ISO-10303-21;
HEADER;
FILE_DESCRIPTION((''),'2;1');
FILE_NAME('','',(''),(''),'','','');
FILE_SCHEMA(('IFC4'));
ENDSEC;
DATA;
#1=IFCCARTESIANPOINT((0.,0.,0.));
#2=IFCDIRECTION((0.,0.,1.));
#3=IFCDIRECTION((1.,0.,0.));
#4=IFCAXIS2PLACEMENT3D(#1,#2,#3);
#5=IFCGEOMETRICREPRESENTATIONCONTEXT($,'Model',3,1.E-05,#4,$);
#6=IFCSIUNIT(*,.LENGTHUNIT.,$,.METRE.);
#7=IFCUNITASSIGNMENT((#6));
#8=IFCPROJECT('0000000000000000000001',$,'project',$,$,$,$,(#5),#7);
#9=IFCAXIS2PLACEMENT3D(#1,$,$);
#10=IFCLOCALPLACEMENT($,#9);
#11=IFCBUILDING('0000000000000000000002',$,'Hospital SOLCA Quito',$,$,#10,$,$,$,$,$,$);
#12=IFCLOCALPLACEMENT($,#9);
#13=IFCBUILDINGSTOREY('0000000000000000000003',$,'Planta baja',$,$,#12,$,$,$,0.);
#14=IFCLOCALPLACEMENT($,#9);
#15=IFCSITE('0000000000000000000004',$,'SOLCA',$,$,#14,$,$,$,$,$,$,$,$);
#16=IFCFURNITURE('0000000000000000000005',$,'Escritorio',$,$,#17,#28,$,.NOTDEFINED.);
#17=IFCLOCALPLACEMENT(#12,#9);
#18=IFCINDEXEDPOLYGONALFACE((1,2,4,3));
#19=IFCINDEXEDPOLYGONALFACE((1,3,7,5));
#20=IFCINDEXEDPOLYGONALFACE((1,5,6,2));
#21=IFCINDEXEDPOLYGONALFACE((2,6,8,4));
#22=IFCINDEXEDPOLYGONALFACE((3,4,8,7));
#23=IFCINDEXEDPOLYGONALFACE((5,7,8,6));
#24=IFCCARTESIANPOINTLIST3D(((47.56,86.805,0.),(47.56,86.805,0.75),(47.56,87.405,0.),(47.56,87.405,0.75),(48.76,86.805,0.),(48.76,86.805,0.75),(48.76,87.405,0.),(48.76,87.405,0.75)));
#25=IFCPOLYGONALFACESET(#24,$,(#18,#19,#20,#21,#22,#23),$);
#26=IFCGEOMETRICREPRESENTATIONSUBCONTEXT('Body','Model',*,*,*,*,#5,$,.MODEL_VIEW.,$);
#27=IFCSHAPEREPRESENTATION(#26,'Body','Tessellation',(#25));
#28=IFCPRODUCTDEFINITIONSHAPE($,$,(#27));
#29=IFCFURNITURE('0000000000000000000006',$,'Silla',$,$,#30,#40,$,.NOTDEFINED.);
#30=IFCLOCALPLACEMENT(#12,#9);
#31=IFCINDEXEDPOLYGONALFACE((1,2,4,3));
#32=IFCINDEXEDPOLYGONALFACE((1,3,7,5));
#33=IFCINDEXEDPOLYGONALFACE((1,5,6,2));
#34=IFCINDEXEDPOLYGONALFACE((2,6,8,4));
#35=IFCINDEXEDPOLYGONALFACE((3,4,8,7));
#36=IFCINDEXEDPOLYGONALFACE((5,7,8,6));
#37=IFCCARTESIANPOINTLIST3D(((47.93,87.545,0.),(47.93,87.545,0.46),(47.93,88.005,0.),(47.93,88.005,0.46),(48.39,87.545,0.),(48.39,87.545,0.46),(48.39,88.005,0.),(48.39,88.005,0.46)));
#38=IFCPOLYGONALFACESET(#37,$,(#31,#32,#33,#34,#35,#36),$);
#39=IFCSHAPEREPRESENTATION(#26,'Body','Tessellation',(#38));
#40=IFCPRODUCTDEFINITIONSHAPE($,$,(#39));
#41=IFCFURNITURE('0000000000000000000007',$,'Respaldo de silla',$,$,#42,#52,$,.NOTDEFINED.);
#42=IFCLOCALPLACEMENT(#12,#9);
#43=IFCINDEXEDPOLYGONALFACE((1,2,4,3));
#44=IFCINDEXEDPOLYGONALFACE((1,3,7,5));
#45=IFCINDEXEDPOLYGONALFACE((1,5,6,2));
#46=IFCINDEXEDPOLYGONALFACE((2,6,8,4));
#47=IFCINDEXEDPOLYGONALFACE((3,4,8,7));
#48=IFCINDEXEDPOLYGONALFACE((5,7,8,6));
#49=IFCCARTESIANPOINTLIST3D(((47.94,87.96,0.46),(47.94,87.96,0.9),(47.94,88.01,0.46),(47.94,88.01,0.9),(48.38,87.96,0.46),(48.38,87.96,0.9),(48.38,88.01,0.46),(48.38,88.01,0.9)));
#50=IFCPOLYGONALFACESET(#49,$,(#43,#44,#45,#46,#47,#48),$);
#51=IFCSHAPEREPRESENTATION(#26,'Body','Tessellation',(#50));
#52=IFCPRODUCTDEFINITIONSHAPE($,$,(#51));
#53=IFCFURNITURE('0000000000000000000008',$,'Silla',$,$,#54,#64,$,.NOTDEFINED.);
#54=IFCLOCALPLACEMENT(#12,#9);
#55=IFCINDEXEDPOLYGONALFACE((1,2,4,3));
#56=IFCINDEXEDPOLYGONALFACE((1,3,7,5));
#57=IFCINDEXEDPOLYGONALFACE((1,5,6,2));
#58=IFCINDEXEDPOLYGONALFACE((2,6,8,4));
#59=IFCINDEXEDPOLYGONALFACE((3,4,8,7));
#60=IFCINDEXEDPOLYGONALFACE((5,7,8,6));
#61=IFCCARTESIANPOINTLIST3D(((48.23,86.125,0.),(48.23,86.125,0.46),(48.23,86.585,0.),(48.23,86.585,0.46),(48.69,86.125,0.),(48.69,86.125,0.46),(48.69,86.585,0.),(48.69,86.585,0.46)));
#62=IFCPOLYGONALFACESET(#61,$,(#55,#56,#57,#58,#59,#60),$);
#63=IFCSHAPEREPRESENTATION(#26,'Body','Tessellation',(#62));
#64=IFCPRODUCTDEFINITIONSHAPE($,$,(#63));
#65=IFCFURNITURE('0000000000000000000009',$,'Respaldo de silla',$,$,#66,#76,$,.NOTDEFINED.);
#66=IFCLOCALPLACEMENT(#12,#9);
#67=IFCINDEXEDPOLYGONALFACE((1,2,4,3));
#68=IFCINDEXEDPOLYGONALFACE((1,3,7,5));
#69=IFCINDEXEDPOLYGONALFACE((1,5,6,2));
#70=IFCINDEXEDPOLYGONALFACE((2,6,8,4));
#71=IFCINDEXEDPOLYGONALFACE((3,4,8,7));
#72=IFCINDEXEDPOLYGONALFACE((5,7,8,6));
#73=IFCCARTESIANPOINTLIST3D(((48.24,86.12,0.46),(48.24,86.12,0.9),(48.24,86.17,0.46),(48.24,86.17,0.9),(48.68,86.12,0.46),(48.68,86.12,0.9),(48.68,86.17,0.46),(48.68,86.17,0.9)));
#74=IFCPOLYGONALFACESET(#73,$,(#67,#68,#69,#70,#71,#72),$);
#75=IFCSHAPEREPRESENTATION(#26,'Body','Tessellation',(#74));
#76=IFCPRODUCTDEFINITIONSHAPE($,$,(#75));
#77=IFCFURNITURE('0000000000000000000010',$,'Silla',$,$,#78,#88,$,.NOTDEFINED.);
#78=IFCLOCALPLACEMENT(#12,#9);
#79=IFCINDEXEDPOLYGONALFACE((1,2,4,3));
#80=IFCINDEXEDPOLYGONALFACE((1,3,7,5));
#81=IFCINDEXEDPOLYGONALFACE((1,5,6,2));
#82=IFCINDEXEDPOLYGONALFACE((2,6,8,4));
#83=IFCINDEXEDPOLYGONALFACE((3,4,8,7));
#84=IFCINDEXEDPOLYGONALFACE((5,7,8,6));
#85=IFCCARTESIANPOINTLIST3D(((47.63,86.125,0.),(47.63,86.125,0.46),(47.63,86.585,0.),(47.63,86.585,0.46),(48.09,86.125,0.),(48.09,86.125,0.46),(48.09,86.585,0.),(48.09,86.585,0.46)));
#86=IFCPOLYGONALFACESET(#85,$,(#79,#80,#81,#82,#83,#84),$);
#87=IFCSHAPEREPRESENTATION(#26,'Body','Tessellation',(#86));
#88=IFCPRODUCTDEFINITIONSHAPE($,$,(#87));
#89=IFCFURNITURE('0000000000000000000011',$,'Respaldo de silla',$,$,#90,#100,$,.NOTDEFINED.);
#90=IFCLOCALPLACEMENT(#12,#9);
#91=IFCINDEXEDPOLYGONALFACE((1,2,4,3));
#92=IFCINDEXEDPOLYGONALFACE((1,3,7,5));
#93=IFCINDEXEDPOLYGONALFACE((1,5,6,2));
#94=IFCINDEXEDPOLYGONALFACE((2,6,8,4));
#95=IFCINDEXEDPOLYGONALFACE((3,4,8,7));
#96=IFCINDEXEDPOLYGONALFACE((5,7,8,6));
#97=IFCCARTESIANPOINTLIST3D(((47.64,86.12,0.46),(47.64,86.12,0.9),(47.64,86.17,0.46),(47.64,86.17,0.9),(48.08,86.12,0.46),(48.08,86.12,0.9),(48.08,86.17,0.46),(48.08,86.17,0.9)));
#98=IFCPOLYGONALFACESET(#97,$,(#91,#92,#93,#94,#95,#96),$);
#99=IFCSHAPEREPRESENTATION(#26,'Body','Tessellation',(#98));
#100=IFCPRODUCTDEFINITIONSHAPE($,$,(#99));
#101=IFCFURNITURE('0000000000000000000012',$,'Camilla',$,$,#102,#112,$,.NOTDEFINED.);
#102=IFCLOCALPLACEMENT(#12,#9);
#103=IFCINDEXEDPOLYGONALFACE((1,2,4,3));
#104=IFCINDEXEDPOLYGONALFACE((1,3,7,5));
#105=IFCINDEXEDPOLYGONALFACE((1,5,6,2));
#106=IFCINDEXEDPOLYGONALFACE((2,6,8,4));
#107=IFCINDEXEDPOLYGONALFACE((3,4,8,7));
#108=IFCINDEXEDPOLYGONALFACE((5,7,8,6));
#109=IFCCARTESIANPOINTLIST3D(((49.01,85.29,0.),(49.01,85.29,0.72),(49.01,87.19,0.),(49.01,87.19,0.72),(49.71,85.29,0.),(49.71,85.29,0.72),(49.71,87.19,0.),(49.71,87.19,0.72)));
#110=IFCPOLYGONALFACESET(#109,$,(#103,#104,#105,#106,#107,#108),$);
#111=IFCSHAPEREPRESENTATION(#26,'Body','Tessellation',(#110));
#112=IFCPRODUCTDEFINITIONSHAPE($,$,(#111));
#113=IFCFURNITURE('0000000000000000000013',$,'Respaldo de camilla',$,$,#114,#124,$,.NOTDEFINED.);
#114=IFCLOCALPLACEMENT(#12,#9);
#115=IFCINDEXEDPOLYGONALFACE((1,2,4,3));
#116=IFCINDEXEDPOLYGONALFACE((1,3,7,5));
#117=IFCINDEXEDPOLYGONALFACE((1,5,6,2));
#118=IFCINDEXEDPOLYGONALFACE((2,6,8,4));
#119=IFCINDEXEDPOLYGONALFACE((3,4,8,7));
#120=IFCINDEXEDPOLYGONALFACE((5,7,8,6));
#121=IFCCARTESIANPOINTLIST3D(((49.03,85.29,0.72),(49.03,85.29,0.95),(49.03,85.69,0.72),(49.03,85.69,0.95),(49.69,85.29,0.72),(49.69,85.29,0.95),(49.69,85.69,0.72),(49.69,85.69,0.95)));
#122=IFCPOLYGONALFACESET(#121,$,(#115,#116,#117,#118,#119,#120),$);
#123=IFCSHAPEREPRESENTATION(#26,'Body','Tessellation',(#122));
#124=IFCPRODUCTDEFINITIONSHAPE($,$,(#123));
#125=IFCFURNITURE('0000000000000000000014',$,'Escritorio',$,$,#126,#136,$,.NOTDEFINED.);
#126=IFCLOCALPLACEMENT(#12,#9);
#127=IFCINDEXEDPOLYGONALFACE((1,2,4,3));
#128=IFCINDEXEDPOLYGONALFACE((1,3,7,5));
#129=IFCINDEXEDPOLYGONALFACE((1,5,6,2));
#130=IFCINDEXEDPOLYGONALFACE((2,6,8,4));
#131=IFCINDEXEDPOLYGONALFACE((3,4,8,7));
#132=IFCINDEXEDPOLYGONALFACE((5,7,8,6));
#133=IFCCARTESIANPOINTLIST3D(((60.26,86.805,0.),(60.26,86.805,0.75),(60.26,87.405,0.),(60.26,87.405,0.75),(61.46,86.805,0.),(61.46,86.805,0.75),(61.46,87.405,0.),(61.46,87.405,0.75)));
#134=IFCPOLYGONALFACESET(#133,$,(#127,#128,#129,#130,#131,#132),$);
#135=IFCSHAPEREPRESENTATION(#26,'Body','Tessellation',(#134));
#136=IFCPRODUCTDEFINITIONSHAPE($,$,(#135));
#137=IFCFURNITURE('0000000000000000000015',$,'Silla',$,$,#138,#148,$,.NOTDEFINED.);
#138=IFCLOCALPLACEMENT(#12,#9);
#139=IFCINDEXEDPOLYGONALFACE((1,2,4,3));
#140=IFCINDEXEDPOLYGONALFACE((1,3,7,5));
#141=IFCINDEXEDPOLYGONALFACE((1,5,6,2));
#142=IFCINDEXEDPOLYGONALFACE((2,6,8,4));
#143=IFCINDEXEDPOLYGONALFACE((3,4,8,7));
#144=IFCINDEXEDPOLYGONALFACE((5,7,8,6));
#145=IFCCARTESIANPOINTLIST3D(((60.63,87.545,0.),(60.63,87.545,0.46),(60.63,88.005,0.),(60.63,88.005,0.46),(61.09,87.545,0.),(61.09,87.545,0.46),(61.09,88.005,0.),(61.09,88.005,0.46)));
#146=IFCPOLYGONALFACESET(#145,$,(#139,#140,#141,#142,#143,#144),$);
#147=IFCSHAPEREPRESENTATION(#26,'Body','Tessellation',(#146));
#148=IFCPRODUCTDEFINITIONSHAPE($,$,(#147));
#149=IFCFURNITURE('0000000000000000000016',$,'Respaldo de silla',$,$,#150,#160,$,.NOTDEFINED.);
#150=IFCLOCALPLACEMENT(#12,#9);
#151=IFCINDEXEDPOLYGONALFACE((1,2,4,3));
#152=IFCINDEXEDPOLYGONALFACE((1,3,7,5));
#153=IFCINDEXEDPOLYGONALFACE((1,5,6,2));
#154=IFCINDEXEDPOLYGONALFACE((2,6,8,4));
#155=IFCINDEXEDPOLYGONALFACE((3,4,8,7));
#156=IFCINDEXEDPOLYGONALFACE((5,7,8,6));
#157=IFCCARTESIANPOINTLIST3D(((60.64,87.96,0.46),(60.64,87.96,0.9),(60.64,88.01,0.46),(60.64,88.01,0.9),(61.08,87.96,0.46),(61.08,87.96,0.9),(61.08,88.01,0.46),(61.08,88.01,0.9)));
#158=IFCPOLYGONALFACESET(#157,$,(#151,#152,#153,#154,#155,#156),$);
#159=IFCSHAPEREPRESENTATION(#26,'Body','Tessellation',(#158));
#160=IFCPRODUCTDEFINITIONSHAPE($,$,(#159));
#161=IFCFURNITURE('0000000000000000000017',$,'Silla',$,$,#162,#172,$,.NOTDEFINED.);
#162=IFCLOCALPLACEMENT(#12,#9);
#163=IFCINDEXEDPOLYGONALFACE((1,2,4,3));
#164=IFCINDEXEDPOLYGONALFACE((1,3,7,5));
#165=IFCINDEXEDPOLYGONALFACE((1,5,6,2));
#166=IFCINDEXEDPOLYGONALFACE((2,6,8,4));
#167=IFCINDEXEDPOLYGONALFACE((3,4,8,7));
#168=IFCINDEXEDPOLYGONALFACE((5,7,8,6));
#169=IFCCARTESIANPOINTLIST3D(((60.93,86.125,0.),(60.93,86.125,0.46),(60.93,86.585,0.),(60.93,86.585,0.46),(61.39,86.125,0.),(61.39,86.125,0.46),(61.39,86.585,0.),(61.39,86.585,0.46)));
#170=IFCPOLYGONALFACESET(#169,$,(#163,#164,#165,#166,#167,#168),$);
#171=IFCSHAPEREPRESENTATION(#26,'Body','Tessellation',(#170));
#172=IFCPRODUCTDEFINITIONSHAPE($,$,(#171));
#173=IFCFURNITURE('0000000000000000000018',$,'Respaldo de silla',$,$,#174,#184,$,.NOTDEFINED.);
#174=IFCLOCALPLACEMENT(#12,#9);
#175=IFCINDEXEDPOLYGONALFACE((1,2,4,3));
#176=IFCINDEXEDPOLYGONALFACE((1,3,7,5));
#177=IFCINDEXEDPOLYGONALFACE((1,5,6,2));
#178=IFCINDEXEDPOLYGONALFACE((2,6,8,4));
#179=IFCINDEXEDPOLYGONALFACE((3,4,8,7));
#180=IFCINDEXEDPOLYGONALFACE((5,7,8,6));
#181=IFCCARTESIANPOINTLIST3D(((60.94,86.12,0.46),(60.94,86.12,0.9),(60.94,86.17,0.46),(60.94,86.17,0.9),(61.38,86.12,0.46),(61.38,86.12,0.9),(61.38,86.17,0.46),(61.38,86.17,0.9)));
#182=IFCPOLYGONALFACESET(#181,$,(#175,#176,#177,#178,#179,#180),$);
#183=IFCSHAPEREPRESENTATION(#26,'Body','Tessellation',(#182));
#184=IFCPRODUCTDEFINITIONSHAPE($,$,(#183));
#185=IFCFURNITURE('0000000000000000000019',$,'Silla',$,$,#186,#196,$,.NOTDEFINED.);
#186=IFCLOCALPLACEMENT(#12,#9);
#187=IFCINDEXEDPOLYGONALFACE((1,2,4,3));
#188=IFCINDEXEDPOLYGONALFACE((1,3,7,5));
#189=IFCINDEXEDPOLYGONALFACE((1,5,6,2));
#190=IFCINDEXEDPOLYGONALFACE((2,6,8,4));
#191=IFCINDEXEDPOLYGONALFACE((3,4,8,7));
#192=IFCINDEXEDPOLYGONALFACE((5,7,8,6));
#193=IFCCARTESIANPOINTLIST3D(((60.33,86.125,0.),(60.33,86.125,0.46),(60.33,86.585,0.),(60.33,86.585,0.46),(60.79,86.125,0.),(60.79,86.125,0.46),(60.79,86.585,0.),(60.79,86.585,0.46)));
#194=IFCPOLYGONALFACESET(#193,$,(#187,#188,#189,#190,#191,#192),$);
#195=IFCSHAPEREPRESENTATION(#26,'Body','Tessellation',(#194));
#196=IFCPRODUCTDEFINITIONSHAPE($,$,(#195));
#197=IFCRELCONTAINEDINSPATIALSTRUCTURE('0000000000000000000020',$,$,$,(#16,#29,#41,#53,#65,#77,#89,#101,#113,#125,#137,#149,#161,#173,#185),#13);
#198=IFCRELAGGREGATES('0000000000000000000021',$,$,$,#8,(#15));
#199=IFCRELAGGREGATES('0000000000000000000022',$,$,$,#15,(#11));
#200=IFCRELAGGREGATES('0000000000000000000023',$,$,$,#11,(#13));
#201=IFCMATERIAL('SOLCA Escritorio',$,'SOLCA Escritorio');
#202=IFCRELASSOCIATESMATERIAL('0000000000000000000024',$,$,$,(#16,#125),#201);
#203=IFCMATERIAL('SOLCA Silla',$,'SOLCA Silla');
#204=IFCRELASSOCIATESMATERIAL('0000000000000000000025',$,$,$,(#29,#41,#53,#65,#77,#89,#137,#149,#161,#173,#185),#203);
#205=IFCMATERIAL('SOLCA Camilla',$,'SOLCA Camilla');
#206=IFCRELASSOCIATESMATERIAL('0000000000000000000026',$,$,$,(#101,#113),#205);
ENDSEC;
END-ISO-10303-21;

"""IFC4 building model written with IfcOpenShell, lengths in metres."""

from ifc_helpers import new_model, si_unit, frame, origin, origin_with_axes, place, context, subcontext, project, spatial, polyline, outline, extrude, material, element, save


model = new_model("IFC4")

# Units and contexts
model_context = context("Model", 3, precision=1e-05, world=origin_with_axes())
body_context = subcontext(model_context, "Body", "Model", "MODEL_VIEW")
ifc_project = project(units=[si_unit("LENGTHUNIT", "METRE")], contexts=[model_context])

# Site, building, storey
site_placement = place(None, origin())
site = spatial("IfcSite", under=ifc_project, at=site_placement, Name="SOLCA")
building_placement = place(None, origin())
building = spatial("IfcBuilding", under=site, at=building_placement, Name="Hospital SOLCA Quito")
storey_placement = place(None, origin())
storey = spatial("IfcBuildingStorey", under=building, at=storey_placement, Name="Planta baja", Elevation=0.0)

# Furniture
ifc_material_1 = material(Name="SOLCA Escritorio", Category="SOLCA Escritorio")
furniture_1_placement = place(storey_placement, origin_with_axes())
element("IfcFurniture", 1, at=furniture_1_placement, inside=storey, material=ifc_material_1, Name="Escritorio", PredefinedType="NOTDEFINED", context=body_context, shape_type="SweptSolid", body=[
    extrude(outline(polyline([(48.76, 87.405), (47.56, 87.405), (47.56, 86.805), (48.76, 86.805), (48.76, 87.405)])), origin_with_axes(), (0.0, 0.0, 1.0), 0.75),
])
ifc_material_2 = material(Name="SOLCA Silla", Category="SOLCA Silla")
furniture_2_placement = place(storey_placement, origin_with_axes())
element("IfcFurniture", 2, at=furniture_2_placement, inside=storey, material=ifc_material_2, Name="Silla", PredefinedType="NOTDEFINED", context=body_context, shape_type="SweptSolid", body=[
    extrude(outline(polyline([(48.39, 88.005), (47.93, 88.005), (47.93, 87.545), (48.39, 87.545), (48.39, 88.005)])), origin_with_axes(), (0.0, 0.0, 1.0), 0.46),
])
furniture_3_placement = place(storey_placement, origin_with_axes())
element("IfcFurniture", 3, at=furniture_3_placement, inside=storey, material=ifc_material_2, Name="Respaldo de silla", PredefinedType="NOTDEFINED", context=body_context, shape_type="SweptSolid", body=[
    extrude(outline(polyline([(48.38, 88.01), (47.94, 88.01), (47.94, 87.96), (48.38, 87.96), (48.38, 88.01)])), frame((0.0, 0.0, 0.46), z_axis=(0.0, 0.0, 1.0), x_axis=(1.0, 0.0, 0.0)), (0.0, 0.0, 1.0), 0.44),
])
furniture_4_placement = place(storey_placement, origin_with_axes())
element("IfcFurniture", 4, at=furniture_4_placement, inside=storey, material=ifc_material_2, Name="Silla", PredefinedType="NOTDEFINED", context=body_context, shape_type="SweptSolid", body=[
    extrude(outline(polyline([(48.69, 86.585), (48.23, 86.585), (48.23, 86.125), (48.69, 86.125), (48.69, 86.585)])), origin_with_axes(), (0.0, 0.0, 1.0), 0.46),
])
furniture_5_placement = place(storey_placement, origin_with_axes())
element("IfcFurniture", 5, at=furniture_5_placement, inside=storey, material=ifc_material_2, Name="Respaldo de silla", PredefinedType="NOTDEFINED", context=body_context, shape_type="SweptSolid", body=[
    extrude(outline(polyline([(48.68, 86.17), (48.24, 86.17), (48.24, 86.12), (48.68, 86.12), (48.68, 86.17)])), frame((0.0, 0.0, 0.46), z_axis=(0.0, 0.0, 1.0), x_axis=(1.0, 0.0, 0.0)), (0.0, 0.0, 1.0), 0.44),
])
furniture_6_placement = place(storey_placement, origin_with_axes())
element("IfcFurniture", 6, at=furniture_6_placement, inside=storey, material=ifc_material_2, Name="Silla", PredefinedType="NOTDEFINED", context=body_context, shape_type="SweptSolid", body=[
    extrude(outline(polyline([(48.09, 86.585), (47.63, 86.585), (47.63, 86.125), (48.09, 86.125), (48.09, 86.585)])), origin_with_axes(), (0.0, 0.0, 1.0), 0.46),
])
furniture_7_placement = place(storey_placement, origin_with_axes())
element("IfcFurniture", 7, at=furniture_7_placement, inside=storey, material=ifc_material_2, Name="Respaldo de silla", PredefinedType="NOTDEFINED", context=body_context, shape_type="SweptSolid", body=[
    extrude(outline(polyline([(48.08, 86.17), (47.64, 86.17), (47.64, 86.12), (48.08, 86.12), (48.08, 86.17)])), frame((0.0, 0.0, 0.46), z_axis=(0.0, 0.0, 1.0), x_axis=(1.0, 0.0, 0.0)), (0.0, 0.0, 1.0), 0.44),
])
ifc_material_3 = material(Name="SOLCA Camilla", Category="SOLCA Camilla")
furniture_8_placement = place(storey_placement, origin_with_axes())
element("IfcFurniture", 8, at=furniture_8_placement, inside=storey, material=ifc_material_3, Name="Camilla", PredefinedType="NOTDEFINED", context=body_context, shape_type="SweptSolid", body=[
    extrude(outline(polyline([(49.01, 87.19), (49.01, 85.29), (49.71, 85.29), (49.71, 87.19), (49.01, 87.19)])), origin_with_axes(), (0.0, 0.0, 1.0), 0.72),
])
furniture_9_placement = place(storey_placement, origin_with_axes())
element("IfcFurniture", 9, at=furniture_9_placement, inside=storey, material=ifc_material_3, Name="Respaldo de camilla", PredefinedType="NOTDEFINED", context=body_context, shape_type="SweptSolid", body=[
    extrude(outline(polyline([(49.03, 85.69), (49.03, 85.29), (49.69, 85.29), (49.69, 85.69), (49.03, 85.69)])), frame((0.0, 0.0, 0.72), z_axis=(0.0, 0.0, 1.0), x_axis=(1.0, 0.0, 0.0)), (0.0, 0.0, 1.0), 0.23),
])
furniture_10_placement = place(storey_placement, origin_with_axes())
element("IfcFurniture", 10, at=furniture_10_placement, inside=storey, material=ifc_material_1, Name="Escritorio", PredefinedType="NOTDEFINED", context=body_context, shape_type="SweptSolid", body=[
    extrude(outline(polyline([(61.46, 87.405), (60.26, 87.405), (60.26, 86.805), (61.46, 86.805), (61.46, 87.405)])), origin_with_axes(), (0.0, 0.0, 1.0), 0.75),
])
furniture_11_placement = place(storey_placement, origin_with_axes())
element("IfcFurniture", 11, at=furniture_11_placement, inside=storey, material=ifc_material_2, Name="Silla", PredefinedType="NOTDEFINED", context=body_context, shape_type="SweptSolid", body=[
    extrude(outline(polyline([(61.09, 88.005), (60.63, 88.005), (60.63, 87.545), (61.09, 87.545), (61.09, 88.005)])), origin_with_axes(), (0.0, 0.0, 1.0), 0.46),
])
furniture_12_placement = place(storey_placement, origin_with_axes())
element("IfcFurniture", 12, at=furniture_12_placement, inside=storey, material=ifc_material_2, Name="Respaldo de silla", PredefinedType="NOTDEFINED", context=body_context, shape_type="SweptSolid", body=[
    extrude(outline(polyline([(61.08, 88.01), (60.64, 88.01), (60.64, 87.96), (61.08, 87.96), (61.08, 88.01)])), frame((0.0, 0.0, 0.46), z_axis=(0.0, 0.0, 1.0), x_axis=(1.0, 0.0, 0.0)), (0.0, 0.0, 1.0), 0.44),
])
furniture_13_placement = place(storey_placement, origin_with_axes())
element("IfcFurniture", 13, at=furniture_13_placement, inside=storey, material=ifc_material_2, Name="Silla", PredefinedType="NOTDEFINED", context=body_context, shape_type="SweptSolid", body=[
    extrude(outline(polyline([(61.39, 86.585), (60.93, 86.585), (60.93, 86.125), (61.39, 86.125), (61.39, 86.585)])), origin_with_axes(), (0.0, 0.0, 1.0), 0.46),
])
furniture_14_placement = place(storey_placement, origin_with_axes())
element("IfcFurniture", 14, at=furniture_14_placement, inside=storey, material=ifc_material_2, Name="Respaldo de silla", PredefinedType="NOTDEFINED", context=body_context, shape_type="SweptSolid", body=[
    extrude(outline(polyline([(61.38, 86.17), (60.94, 86.17), (60.94, 86.12), (61.38, 86.12), (61.38, 86.17)])), frame((0.0, 0.0, 0.46), z_axis=(0.0, 0.0, 1.0), x_axis=(1.0, 0.0, 0.0)), (0.0, 0.0, 1.0), 0.44),
])
furniture_15_placement = place(storey_placement, origin_with_axes())
element("IfcFurniture", 15, at=furniture_15_placement, inside=storey, material=ifc_material_2, Name="Silla", PredefinedType="NOTDEFINED", context=body_context, shape_type="SweptSolid", body=[
    extrude(outline(polyline([(60.79, 86.585), (60.33, 86.585), (60.33, 86.125), (60.79, 86.125), (60.79, 86.585)])), origin_with_axes(), (0.0, 0.0, 1.0), 0.46),
])

save(model, "model.ifc")
